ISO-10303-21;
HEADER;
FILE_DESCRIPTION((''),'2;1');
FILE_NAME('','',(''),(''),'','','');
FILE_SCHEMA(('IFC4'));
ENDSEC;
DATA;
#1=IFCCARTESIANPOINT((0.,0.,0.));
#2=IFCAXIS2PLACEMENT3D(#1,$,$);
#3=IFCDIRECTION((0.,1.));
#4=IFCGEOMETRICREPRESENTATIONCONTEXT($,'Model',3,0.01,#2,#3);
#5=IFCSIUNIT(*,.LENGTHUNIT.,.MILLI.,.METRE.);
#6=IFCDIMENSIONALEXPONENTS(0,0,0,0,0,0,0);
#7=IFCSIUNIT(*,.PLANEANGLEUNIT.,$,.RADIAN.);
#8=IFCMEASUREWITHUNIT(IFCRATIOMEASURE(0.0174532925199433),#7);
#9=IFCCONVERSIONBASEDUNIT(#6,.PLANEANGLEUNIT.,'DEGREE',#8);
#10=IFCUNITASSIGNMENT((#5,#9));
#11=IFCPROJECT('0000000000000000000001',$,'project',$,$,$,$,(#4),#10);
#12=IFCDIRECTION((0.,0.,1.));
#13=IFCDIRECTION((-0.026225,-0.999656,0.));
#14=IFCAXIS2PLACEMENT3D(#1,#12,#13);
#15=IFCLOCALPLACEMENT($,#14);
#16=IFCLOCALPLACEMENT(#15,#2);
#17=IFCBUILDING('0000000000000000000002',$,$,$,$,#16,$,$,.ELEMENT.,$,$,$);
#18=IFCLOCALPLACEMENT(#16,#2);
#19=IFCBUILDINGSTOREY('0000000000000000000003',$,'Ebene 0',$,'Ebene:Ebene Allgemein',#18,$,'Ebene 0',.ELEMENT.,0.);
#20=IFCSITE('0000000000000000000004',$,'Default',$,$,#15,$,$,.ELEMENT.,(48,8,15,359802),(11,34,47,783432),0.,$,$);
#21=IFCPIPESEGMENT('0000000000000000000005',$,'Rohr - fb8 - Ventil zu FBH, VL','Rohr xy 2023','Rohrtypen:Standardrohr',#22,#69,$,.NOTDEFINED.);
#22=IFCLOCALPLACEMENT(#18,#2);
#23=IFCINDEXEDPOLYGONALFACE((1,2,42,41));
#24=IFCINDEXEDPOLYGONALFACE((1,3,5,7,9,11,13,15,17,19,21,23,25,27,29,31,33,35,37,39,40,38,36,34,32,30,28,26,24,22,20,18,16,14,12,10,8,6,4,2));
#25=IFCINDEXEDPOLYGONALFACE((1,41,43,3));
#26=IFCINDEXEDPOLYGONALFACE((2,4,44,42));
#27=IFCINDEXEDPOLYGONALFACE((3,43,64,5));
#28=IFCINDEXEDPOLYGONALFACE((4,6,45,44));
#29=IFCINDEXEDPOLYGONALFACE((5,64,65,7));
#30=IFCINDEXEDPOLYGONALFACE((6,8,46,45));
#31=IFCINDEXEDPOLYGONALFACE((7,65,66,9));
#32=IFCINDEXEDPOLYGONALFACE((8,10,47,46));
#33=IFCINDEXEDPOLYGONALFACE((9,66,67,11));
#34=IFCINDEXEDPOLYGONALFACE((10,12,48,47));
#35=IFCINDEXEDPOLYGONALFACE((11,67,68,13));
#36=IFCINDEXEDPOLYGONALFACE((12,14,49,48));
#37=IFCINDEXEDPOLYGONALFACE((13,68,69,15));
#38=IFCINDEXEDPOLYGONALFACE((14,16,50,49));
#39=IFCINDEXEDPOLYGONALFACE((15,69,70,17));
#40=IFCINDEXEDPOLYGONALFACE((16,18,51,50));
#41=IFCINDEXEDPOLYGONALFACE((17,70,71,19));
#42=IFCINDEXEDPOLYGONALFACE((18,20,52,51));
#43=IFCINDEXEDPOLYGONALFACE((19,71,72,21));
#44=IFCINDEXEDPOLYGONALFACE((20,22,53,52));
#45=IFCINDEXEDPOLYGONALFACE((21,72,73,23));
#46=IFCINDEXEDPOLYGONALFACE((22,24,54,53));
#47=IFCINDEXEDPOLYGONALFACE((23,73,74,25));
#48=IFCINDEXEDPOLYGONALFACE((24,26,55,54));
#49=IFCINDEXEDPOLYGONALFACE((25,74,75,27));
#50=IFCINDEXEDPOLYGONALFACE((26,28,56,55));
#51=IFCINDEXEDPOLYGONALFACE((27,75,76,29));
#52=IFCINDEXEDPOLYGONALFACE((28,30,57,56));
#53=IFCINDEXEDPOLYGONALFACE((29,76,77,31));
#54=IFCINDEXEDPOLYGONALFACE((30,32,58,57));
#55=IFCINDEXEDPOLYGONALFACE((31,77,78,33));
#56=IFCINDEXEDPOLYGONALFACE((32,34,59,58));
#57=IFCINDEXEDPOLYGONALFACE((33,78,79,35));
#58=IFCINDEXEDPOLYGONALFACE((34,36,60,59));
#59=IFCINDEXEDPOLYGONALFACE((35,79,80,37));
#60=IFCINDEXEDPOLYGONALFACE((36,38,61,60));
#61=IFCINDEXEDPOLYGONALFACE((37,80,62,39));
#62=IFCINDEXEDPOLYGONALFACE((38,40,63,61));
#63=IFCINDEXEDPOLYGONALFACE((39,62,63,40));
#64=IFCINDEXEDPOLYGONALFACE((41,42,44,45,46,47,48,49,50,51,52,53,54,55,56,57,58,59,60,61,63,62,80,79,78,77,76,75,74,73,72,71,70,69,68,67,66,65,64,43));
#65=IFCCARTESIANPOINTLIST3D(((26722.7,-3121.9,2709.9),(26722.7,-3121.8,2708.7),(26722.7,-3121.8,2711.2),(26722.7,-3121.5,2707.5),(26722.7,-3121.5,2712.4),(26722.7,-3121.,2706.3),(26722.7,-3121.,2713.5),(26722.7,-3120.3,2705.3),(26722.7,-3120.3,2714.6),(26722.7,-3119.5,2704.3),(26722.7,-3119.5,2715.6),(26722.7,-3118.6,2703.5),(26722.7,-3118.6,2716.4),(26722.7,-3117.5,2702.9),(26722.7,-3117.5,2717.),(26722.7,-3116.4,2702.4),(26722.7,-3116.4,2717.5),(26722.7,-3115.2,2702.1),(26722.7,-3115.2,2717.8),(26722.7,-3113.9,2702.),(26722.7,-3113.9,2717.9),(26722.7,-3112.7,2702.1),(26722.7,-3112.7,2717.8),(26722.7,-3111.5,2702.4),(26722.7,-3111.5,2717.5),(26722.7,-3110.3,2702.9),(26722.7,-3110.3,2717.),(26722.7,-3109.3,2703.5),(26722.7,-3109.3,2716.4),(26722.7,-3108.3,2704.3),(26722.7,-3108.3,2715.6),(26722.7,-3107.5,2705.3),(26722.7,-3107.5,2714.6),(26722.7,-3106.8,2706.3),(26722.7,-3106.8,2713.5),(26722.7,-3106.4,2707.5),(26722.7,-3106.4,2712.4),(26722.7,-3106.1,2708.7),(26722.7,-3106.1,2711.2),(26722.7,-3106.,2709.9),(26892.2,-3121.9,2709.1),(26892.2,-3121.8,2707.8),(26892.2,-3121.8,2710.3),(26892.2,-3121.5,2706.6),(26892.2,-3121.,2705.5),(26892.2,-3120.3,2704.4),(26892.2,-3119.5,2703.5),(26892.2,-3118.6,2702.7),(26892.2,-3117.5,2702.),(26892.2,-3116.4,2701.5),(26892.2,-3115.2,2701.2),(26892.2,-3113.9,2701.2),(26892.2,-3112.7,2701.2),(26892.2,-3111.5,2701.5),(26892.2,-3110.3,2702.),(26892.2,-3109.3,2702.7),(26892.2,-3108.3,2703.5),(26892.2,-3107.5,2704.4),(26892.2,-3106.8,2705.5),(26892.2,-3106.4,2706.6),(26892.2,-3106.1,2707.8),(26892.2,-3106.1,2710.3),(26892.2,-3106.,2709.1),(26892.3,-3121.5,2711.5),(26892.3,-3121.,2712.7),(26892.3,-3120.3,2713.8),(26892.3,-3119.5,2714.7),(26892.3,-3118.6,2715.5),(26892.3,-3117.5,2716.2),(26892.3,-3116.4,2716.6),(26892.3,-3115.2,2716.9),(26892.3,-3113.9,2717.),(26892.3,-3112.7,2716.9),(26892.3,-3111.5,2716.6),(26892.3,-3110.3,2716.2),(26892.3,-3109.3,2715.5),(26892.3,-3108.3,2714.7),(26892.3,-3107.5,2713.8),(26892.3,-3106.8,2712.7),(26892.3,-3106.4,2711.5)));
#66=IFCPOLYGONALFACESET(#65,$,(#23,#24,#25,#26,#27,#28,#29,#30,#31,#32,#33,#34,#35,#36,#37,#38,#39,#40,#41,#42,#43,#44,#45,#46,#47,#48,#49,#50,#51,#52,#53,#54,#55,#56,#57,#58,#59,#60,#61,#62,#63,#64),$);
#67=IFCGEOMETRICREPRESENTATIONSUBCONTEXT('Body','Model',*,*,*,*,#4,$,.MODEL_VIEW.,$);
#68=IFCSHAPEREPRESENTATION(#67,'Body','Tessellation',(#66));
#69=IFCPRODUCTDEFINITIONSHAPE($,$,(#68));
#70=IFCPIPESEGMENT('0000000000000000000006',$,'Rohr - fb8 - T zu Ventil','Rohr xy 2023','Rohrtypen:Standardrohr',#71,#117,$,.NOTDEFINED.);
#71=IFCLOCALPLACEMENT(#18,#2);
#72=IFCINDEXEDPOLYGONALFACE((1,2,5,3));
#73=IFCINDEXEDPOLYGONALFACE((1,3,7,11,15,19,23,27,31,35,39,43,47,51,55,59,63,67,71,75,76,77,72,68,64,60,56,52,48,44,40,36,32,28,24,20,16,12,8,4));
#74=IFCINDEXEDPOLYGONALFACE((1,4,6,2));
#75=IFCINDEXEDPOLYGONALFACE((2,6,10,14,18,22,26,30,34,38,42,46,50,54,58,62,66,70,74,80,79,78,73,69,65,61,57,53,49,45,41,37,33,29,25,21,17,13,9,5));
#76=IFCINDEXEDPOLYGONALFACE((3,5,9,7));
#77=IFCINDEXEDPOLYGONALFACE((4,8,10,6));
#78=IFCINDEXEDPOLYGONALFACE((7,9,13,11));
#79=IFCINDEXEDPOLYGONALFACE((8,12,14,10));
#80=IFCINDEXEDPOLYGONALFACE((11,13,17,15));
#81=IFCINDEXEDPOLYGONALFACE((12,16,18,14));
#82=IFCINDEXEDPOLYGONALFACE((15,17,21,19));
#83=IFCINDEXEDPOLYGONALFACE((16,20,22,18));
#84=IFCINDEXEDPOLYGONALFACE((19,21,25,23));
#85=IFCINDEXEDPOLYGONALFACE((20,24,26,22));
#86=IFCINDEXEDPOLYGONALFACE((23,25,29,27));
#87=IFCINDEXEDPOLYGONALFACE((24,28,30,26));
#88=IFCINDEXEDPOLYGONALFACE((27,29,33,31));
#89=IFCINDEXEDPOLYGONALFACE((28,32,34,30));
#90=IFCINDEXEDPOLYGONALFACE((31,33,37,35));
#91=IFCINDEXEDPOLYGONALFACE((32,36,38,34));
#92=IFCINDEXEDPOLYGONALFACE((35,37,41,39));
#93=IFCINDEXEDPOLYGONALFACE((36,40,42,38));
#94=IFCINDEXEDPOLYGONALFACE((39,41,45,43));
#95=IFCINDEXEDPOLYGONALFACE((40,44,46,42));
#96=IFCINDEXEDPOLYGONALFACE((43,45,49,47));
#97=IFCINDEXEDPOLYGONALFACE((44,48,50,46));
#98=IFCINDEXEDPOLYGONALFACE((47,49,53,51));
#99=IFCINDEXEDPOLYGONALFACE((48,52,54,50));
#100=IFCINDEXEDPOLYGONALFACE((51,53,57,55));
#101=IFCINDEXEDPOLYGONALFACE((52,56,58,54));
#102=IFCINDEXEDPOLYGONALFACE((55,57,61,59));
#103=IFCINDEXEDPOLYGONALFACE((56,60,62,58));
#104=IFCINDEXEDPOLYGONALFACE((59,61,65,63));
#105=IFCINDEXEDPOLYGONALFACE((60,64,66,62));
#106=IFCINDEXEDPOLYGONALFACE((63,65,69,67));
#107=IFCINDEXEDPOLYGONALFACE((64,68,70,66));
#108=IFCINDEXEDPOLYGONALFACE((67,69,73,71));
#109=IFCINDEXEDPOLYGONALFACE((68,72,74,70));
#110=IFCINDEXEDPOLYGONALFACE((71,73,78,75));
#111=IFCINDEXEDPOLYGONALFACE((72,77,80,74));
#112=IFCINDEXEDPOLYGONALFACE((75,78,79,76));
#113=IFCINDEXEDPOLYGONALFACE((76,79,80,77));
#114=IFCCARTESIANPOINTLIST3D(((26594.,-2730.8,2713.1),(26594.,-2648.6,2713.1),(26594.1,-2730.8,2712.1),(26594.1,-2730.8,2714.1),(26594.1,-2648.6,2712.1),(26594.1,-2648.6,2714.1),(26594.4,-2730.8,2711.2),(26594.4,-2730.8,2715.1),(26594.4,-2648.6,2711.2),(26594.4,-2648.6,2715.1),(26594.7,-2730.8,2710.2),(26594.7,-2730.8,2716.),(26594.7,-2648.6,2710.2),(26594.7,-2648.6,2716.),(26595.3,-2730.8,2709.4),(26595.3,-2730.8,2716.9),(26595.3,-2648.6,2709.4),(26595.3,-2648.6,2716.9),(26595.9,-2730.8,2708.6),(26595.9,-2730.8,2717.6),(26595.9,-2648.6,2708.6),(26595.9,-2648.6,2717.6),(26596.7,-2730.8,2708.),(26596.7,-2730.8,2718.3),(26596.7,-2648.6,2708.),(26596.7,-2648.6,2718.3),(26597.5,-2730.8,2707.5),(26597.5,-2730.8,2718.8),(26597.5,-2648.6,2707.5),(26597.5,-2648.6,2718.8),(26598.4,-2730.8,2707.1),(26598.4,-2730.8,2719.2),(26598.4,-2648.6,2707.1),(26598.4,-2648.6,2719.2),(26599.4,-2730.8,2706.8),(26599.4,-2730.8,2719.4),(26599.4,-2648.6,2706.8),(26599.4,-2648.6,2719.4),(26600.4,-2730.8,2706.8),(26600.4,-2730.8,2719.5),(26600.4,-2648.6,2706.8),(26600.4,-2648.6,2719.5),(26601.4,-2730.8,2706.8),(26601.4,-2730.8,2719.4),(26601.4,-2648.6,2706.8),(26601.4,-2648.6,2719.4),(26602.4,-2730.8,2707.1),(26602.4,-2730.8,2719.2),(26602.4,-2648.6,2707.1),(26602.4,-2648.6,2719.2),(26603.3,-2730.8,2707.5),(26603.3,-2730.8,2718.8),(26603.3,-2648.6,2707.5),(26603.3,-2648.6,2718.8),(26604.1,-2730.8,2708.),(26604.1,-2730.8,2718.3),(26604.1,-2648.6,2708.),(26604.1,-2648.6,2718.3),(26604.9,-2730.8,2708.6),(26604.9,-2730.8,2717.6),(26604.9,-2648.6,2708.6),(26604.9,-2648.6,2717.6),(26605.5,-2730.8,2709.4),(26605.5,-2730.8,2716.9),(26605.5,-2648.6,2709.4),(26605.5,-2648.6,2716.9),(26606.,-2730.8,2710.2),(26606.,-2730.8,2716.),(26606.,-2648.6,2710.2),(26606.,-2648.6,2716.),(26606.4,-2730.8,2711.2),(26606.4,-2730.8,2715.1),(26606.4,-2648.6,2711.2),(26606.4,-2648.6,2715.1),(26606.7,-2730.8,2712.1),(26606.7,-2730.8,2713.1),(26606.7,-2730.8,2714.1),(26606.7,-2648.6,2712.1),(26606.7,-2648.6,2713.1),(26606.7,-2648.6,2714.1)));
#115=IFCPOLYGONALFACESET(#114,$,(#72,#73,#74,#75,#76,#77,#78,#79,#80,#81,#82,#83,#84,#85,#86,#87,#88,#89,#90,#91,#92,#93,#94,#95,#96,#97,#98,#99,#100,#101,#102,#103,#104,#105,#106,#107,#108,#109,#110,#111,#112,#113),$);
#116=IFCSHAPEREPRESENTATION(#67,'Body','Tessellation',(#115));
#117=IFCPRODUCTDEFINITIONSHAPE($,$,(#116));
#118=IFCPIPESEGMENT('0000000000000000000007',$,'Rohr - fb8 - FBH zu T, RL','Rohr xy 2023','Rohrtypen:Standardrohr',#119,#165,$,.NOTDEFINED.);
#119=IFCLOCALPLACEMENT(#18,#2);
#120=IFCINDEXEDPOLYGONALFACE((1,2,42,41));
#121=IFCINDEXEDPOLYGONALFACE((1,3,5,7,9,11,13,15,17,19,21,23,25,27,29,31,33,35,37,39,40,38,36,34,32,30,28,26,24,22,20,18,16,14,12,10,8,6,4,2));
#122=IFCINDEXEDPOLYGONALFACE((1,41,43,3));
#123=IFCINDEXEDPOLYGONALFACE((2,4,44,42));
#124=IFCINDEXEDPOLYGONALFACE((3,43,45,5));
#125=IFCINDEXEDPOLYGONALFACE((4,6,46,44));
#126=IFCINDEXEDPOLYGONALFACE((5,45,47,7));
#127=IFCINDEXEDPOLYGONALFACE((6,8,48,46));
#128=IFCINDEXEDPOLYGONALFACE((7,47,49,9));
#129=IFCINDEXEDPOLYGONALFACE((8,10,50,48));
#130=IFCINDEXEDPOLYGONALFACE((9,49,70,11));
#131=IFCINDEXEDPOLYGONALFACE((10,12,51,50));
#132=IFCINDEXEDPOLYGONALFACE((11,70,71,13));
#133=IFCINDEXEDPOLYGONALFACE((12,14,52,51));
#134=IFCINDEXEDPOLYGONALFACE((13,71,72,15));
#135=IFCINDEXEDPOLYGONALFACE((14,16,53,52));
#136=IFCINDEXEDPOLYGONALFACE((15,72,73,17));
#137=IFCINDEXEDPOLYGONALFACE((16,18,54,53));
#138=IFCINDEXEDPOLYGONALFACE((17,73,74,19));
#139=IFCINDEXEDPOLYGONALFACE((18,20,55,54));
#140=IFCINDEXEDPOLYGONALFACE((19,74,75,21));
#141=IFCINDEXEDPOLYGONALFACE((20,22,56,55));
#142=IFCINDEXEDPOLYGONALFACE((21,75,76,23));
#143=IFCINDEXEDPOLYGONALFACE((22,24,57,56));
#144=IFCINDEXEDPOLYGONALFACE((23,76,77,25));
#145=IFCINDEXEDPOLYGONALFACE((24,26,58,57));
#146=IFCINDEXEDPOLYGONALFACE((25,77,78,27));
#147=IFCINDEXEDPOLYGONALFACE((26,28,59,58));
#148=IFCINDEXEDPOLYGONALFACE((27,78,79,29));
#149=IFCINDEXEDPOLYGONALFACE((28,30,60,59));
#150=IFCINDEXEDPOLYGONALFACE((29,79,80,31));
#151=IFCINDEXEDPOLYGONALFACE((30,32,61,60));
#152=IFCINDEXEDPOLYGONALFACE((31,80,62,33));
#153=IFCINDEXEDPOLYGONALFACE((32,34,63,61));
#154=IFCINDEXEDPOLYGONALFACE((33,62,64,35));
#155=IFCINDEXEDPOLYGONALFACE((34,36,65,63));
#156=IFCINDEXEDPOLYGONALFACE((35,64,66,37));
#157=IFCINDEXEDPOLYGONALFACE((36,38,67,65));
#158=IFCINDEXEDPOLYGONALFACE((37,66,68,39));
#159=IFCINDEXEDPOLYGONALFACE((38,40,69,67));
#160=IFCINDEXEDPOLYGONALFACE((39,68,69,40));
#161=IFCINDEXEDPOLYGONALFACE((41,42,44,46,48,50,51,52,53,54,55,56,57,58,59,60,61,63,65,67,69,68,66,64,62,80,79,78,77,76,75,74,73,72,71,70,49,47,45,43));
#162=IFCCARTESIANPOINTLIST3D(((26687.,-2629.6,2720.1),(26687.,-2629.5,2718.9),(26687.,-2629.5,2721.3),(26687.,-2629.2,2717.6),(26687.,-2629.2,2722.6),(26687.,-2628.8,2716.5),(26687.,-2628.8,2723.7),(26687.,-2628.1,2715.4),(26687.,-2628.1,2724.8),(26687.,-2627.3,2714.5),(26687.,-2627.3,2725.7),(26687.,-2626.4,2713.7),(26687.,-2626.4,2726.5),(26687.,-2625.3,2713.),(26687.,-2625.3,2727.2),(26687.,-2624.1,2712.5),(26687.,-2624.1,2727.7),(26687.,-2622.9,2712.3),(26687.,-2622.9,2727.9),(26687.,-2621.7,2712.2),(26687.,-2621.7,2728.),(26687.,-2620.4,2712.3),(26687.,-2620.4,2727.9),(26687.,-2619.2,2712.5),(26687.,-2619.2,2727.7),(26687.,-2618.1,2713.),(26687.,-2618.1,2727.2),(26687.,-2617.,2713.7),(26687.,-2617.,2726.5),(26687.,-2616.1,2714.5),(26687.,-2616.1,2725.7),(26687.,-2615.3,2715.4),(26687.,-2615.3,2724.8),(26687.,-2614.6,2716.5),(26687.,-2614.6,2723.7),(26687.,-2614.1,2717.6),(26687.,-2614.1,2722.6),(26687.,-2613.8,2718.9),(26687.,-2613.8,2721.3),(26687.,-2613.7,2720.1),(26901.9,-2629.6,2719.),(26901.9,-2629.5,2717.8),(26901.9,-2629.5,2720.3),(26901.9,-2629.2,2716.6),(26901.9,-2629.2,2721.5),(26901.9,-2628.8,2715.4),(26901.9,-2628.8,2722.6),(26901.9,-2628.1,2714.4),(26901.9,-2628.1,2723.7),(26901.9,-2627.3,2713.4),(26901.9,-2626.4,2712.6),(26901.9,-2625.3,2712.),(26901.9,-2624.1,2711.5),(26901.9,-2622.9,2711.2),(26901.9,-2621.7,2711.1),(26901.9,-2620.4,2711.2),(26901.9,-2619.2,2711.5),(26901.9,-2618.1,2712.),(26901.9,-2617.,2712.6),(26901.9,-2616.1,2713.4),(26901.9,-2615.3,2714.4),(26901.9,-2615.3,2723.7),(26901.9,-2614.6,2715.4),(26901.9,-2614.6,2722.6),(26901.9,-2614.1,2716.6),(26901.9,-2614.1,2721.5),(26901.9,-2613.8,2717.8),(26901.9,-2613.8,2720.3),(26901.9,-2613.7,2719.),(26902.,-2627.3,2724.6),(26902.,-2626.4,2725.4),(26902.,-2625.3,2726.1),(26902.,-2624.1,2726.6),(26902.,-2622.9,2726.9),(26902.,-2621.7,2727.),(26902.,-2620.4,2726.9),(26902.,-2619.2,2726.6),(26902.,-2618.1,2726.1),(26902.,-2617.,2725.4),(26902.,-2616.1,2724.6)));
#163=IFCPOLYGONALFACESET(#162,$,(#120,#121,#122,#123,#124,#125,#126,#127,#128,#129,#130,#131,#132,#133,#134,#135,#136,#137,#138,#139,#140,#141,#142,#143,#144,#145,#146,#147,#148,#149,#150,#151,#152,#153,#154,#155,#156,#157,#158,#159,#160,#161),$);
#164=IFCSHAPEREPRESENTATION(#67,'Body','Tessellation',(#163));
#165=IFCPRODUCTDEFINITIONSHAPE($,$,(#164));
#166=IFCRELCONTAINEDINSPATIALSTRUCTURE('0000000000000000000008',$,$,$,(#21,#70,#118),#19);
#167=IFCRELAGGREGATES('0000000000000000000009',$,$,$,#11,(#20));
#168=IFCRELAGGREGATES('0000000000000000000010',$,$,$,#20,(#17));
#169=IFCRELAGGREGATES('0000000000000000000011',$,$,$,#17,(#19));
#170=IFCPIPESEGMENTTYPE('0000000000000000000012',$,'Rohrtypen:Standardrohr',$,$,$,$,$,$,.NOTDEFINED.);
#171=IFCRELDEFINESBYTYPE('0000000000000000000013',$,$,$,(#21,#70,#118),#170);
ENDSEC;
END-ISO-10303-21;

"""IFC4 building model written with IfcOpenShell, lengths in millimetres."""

from ifc_helpers import new_model, entity, si_unit, converted_unit, direction, frame, origin, place, context, subcontext, project, spatial, indexed_curve, outline, extrude, type_object, element, save


model = new_model("IFC4")

# Units and contexts
model_context = context("Model", 3, precision=0.01, world=origin(), true_north=direction((0.0, 1.0)))
body_context = subcontext(model_context, "Body", "Model", "MODEL_VIEW")
ifc_project = project(units=[si_unit("LENGTHUNIT", "METRE", prefix="MILLI"), converted_unit("PLANEANGLEUNIT", "DEGREE", entity("IfcRatioMeasure", 0.0174532925199433), si_unit("PLANEANGLEUNIT", "RADIAN"), dimensions=[0, 0, 0, 0, 0, 0, 0])], contexts=[model_context])

# Site, building, storey
site_placement = place(None, frame((0.0, 0.0, 0.0), z_axis=(0.0, 0.0, 1.0), x_axis=(-0.026225, -0.999656, 0.0)))
site = spatial("IfcSite", under=ifc_project, at=site_placement, Name="Default", CompositionType="ELEMENT", RefLatitude=(48, 8, 15, 359802), RefLongitude=(11, 34, 47, 783432), RefElevation=0.0)
building_placement = place(site_placement, origin())
building = spatial("IfcBuilding", under=site, at=building_placement, CompositionType="ELEMENT")
storey_placement = place(building_placement, origin())
storey = spatial("IfcBuildingStorey", under=building, at=storey_placement, Name="Ebene 0", ObjectType="Ebene:Ebene Allgemein", LongName="Ebene 0", CompositionType="ELEMENT", Elevation=0.0)

# Pipe segments
pipe_segment_type = type_object("IfcPipeSegmentType", Name="Rohrtypen:Standardrohr", PredefinedType="NOTDEFINED")
pipe_segment_1_placement = place(storey_placement, origin())
element("IfcPipeSegment", 1, at=pipe_segment_1_placement, inside=storey, type_object=pipe_segment_type, Name="Rohr - fb8 - Ventil zu FBH, VL", Description="Rohr xy 2023", ObjectType="Rohrtypen:Standardrohr", PredefinedType="NOTDEFINED", context=body_context, shape_type="SweptSolid", body=[
    extrude(outline(indexed_curve([(7.9, 0.0), (7.8, 1.2), (7.6, 2.5), (7.1, 3.6), (6.4, 4.7), (5.6, 5.6), (4.7, 6.4), (3.6, 7.1), (2.5, 7.6), (1.2, 7.8), (0.0, 7.9), (-1.2, 7.8), (-2.5, 7.6), (-3.6, 7.1), (-4.7, 6.4), (-5.6, 5.6), (-6.4, 4.7), (-7.1, 3.6), (-7.6, 2.5), (-7.8, 1.2), (-7.9, 0.0), (-7.8, -1.2), (-7.6, -2.5), (-7.1, -3.6), (-6.4, -4.7), (-5.6, -5.6), (-4.7, -6.4), (-3.6, -7.1), (-2.5, -7.6), (-1.2, -7.8), (0.0, -7.9), (1.2, -7.8), (2.5, -7.6), (3.6, -7.1), (4.7, -6.4), (5.6, -5.6), (6.4, -4.7), (7.1, -3.6), (7.6, -2.5), (7.8, -1.2), (7.9, 0.0)], self_intersect=False)), frame((26722.7, -3113.9, 2709.9), z_axis=(0.999988, 0.0, -0.005), x_axis=(0.0, 1.0, 0.0)), (0.0, 0.0, 1.0), 169.5),
])
pipe_segment_2_placement = place(storey_placement, origin())
element("IfcPipeSegment", 2, at=pipe_segment_2_placement, inside=storey, type_object=pipe_segment_type, Name="Rohr - fb8 - T zu Ventil", Description="Rohr xy 2023", ObjectType="Rohrtypen:Standardrohr", PredefinedType="NOTDEFINED", context=body_context, shape_type="SweptSolid", body=[
    extrude(outline(indexed_curve([(6.3, 0.0), (6.3, 1.0), (6.0, 2.0), (5.7, 2.9), (5.1, 3.7), (4.5, 4.5), (3.7, 5.1), (2.9, 5.7), (2.0, 6.0), (1.0, 6.3), (0.0, 6.4), (-1.0, 6.3), (-2.0, 6.0), (-2.9, 5.7), (-3.7, 5.1), (-4.5, 4.5), (-5.1, 3.7), (-5.7, 2.9), (-6.0, 2.0), (-6.3, 1.0), (-6.4, 0.0), (-6.3, -1.0), (-6.0, -2.0), (-5.7, -2.9), (-5.1, -3.7), (-4.5, -4.5), (-3.7, -5.1), (-2.9, -5.7), (-2.0, -6.0), (-1.0, -6.3), (0.0, -6.4), (1.0, -6.3), (2.0, -6.0), (2.9, -5.7), (3.7, -5.1), (4.5, -4.5), (5.1, -3.7), (5.7, -2.9), (6.0, -2.0), (6.3, -1.0), (6.3, 0.0)], self_intersect=False)), frame((26600.4, -2730.8, 2713.1), z_axis=(0.0, 1.0, 0.0), x_axis=(-1.0, 0.0, 0.0)), (0.0, 0.0, 1.0), 82.2),
])
pipe_segment_3_placement = place(storey_placement, origin())
element("IfcPipeSegment", 3, at=pipe_segment_3_placement, inside=storey, type_object=pipe_segment_type, Name="Rohr - fb8 - FBH zu T, RL", Description="Rohr xy 2023", ObjectType="Rohrtypen:Standardrohr", PredefinedType="NOTDEFINED", context=body_context, shape_type="SweptSolid", body=[
    extrude(outline(indexed_curve([(7.9, 0.0), (7.8, 1.2), (7.6, 2.5), (7.1, 3.6), (6.4, 4.7), (5.6, 5.6), (4.7, 6.4), (3.6, 7.1), (2.5, 7.6), (1.2, 7.8), (0.0, 7.9), (-1.2, 7.8), (-2.5, 7.6), (-3.6, 7.1), (-4.7, 6.4), (-5.6, 5.6), (-6.4, 4.7), (-7.1, 3.6), (-7.6, 2.5), (-7.8, 1.2), (-7.9, 0.0), (-7.8, -1.2), (-7.6, -2.5), (-7.1, -3.6), (-6.4, -4.7), (-5.6, -5.6), (-4.7, -6.4), (-3.6, -7.1), (-2.5, -7.6), (-1.2, -7.8), (0.0, -7.9), (1.2, -7.8), (2.5, -7.6), (3.6, -7.1), (4.7, -6.4), (5.6, -5.6), (6.4, -4.7), (7.1, -3.6), (7.6, -2.5), (7.8, -1.2), (7.9, 0.0)], self_intersect=False)), frame((26901.9, -2621.7, 2719.0), z_axis=(-0.999988, 0.0, 0.005), x_axis=(0.0, 1.0, 0.0)), (0.0, 0.0, 1.0), 214.9),
])

save(model, "model.ifc")
